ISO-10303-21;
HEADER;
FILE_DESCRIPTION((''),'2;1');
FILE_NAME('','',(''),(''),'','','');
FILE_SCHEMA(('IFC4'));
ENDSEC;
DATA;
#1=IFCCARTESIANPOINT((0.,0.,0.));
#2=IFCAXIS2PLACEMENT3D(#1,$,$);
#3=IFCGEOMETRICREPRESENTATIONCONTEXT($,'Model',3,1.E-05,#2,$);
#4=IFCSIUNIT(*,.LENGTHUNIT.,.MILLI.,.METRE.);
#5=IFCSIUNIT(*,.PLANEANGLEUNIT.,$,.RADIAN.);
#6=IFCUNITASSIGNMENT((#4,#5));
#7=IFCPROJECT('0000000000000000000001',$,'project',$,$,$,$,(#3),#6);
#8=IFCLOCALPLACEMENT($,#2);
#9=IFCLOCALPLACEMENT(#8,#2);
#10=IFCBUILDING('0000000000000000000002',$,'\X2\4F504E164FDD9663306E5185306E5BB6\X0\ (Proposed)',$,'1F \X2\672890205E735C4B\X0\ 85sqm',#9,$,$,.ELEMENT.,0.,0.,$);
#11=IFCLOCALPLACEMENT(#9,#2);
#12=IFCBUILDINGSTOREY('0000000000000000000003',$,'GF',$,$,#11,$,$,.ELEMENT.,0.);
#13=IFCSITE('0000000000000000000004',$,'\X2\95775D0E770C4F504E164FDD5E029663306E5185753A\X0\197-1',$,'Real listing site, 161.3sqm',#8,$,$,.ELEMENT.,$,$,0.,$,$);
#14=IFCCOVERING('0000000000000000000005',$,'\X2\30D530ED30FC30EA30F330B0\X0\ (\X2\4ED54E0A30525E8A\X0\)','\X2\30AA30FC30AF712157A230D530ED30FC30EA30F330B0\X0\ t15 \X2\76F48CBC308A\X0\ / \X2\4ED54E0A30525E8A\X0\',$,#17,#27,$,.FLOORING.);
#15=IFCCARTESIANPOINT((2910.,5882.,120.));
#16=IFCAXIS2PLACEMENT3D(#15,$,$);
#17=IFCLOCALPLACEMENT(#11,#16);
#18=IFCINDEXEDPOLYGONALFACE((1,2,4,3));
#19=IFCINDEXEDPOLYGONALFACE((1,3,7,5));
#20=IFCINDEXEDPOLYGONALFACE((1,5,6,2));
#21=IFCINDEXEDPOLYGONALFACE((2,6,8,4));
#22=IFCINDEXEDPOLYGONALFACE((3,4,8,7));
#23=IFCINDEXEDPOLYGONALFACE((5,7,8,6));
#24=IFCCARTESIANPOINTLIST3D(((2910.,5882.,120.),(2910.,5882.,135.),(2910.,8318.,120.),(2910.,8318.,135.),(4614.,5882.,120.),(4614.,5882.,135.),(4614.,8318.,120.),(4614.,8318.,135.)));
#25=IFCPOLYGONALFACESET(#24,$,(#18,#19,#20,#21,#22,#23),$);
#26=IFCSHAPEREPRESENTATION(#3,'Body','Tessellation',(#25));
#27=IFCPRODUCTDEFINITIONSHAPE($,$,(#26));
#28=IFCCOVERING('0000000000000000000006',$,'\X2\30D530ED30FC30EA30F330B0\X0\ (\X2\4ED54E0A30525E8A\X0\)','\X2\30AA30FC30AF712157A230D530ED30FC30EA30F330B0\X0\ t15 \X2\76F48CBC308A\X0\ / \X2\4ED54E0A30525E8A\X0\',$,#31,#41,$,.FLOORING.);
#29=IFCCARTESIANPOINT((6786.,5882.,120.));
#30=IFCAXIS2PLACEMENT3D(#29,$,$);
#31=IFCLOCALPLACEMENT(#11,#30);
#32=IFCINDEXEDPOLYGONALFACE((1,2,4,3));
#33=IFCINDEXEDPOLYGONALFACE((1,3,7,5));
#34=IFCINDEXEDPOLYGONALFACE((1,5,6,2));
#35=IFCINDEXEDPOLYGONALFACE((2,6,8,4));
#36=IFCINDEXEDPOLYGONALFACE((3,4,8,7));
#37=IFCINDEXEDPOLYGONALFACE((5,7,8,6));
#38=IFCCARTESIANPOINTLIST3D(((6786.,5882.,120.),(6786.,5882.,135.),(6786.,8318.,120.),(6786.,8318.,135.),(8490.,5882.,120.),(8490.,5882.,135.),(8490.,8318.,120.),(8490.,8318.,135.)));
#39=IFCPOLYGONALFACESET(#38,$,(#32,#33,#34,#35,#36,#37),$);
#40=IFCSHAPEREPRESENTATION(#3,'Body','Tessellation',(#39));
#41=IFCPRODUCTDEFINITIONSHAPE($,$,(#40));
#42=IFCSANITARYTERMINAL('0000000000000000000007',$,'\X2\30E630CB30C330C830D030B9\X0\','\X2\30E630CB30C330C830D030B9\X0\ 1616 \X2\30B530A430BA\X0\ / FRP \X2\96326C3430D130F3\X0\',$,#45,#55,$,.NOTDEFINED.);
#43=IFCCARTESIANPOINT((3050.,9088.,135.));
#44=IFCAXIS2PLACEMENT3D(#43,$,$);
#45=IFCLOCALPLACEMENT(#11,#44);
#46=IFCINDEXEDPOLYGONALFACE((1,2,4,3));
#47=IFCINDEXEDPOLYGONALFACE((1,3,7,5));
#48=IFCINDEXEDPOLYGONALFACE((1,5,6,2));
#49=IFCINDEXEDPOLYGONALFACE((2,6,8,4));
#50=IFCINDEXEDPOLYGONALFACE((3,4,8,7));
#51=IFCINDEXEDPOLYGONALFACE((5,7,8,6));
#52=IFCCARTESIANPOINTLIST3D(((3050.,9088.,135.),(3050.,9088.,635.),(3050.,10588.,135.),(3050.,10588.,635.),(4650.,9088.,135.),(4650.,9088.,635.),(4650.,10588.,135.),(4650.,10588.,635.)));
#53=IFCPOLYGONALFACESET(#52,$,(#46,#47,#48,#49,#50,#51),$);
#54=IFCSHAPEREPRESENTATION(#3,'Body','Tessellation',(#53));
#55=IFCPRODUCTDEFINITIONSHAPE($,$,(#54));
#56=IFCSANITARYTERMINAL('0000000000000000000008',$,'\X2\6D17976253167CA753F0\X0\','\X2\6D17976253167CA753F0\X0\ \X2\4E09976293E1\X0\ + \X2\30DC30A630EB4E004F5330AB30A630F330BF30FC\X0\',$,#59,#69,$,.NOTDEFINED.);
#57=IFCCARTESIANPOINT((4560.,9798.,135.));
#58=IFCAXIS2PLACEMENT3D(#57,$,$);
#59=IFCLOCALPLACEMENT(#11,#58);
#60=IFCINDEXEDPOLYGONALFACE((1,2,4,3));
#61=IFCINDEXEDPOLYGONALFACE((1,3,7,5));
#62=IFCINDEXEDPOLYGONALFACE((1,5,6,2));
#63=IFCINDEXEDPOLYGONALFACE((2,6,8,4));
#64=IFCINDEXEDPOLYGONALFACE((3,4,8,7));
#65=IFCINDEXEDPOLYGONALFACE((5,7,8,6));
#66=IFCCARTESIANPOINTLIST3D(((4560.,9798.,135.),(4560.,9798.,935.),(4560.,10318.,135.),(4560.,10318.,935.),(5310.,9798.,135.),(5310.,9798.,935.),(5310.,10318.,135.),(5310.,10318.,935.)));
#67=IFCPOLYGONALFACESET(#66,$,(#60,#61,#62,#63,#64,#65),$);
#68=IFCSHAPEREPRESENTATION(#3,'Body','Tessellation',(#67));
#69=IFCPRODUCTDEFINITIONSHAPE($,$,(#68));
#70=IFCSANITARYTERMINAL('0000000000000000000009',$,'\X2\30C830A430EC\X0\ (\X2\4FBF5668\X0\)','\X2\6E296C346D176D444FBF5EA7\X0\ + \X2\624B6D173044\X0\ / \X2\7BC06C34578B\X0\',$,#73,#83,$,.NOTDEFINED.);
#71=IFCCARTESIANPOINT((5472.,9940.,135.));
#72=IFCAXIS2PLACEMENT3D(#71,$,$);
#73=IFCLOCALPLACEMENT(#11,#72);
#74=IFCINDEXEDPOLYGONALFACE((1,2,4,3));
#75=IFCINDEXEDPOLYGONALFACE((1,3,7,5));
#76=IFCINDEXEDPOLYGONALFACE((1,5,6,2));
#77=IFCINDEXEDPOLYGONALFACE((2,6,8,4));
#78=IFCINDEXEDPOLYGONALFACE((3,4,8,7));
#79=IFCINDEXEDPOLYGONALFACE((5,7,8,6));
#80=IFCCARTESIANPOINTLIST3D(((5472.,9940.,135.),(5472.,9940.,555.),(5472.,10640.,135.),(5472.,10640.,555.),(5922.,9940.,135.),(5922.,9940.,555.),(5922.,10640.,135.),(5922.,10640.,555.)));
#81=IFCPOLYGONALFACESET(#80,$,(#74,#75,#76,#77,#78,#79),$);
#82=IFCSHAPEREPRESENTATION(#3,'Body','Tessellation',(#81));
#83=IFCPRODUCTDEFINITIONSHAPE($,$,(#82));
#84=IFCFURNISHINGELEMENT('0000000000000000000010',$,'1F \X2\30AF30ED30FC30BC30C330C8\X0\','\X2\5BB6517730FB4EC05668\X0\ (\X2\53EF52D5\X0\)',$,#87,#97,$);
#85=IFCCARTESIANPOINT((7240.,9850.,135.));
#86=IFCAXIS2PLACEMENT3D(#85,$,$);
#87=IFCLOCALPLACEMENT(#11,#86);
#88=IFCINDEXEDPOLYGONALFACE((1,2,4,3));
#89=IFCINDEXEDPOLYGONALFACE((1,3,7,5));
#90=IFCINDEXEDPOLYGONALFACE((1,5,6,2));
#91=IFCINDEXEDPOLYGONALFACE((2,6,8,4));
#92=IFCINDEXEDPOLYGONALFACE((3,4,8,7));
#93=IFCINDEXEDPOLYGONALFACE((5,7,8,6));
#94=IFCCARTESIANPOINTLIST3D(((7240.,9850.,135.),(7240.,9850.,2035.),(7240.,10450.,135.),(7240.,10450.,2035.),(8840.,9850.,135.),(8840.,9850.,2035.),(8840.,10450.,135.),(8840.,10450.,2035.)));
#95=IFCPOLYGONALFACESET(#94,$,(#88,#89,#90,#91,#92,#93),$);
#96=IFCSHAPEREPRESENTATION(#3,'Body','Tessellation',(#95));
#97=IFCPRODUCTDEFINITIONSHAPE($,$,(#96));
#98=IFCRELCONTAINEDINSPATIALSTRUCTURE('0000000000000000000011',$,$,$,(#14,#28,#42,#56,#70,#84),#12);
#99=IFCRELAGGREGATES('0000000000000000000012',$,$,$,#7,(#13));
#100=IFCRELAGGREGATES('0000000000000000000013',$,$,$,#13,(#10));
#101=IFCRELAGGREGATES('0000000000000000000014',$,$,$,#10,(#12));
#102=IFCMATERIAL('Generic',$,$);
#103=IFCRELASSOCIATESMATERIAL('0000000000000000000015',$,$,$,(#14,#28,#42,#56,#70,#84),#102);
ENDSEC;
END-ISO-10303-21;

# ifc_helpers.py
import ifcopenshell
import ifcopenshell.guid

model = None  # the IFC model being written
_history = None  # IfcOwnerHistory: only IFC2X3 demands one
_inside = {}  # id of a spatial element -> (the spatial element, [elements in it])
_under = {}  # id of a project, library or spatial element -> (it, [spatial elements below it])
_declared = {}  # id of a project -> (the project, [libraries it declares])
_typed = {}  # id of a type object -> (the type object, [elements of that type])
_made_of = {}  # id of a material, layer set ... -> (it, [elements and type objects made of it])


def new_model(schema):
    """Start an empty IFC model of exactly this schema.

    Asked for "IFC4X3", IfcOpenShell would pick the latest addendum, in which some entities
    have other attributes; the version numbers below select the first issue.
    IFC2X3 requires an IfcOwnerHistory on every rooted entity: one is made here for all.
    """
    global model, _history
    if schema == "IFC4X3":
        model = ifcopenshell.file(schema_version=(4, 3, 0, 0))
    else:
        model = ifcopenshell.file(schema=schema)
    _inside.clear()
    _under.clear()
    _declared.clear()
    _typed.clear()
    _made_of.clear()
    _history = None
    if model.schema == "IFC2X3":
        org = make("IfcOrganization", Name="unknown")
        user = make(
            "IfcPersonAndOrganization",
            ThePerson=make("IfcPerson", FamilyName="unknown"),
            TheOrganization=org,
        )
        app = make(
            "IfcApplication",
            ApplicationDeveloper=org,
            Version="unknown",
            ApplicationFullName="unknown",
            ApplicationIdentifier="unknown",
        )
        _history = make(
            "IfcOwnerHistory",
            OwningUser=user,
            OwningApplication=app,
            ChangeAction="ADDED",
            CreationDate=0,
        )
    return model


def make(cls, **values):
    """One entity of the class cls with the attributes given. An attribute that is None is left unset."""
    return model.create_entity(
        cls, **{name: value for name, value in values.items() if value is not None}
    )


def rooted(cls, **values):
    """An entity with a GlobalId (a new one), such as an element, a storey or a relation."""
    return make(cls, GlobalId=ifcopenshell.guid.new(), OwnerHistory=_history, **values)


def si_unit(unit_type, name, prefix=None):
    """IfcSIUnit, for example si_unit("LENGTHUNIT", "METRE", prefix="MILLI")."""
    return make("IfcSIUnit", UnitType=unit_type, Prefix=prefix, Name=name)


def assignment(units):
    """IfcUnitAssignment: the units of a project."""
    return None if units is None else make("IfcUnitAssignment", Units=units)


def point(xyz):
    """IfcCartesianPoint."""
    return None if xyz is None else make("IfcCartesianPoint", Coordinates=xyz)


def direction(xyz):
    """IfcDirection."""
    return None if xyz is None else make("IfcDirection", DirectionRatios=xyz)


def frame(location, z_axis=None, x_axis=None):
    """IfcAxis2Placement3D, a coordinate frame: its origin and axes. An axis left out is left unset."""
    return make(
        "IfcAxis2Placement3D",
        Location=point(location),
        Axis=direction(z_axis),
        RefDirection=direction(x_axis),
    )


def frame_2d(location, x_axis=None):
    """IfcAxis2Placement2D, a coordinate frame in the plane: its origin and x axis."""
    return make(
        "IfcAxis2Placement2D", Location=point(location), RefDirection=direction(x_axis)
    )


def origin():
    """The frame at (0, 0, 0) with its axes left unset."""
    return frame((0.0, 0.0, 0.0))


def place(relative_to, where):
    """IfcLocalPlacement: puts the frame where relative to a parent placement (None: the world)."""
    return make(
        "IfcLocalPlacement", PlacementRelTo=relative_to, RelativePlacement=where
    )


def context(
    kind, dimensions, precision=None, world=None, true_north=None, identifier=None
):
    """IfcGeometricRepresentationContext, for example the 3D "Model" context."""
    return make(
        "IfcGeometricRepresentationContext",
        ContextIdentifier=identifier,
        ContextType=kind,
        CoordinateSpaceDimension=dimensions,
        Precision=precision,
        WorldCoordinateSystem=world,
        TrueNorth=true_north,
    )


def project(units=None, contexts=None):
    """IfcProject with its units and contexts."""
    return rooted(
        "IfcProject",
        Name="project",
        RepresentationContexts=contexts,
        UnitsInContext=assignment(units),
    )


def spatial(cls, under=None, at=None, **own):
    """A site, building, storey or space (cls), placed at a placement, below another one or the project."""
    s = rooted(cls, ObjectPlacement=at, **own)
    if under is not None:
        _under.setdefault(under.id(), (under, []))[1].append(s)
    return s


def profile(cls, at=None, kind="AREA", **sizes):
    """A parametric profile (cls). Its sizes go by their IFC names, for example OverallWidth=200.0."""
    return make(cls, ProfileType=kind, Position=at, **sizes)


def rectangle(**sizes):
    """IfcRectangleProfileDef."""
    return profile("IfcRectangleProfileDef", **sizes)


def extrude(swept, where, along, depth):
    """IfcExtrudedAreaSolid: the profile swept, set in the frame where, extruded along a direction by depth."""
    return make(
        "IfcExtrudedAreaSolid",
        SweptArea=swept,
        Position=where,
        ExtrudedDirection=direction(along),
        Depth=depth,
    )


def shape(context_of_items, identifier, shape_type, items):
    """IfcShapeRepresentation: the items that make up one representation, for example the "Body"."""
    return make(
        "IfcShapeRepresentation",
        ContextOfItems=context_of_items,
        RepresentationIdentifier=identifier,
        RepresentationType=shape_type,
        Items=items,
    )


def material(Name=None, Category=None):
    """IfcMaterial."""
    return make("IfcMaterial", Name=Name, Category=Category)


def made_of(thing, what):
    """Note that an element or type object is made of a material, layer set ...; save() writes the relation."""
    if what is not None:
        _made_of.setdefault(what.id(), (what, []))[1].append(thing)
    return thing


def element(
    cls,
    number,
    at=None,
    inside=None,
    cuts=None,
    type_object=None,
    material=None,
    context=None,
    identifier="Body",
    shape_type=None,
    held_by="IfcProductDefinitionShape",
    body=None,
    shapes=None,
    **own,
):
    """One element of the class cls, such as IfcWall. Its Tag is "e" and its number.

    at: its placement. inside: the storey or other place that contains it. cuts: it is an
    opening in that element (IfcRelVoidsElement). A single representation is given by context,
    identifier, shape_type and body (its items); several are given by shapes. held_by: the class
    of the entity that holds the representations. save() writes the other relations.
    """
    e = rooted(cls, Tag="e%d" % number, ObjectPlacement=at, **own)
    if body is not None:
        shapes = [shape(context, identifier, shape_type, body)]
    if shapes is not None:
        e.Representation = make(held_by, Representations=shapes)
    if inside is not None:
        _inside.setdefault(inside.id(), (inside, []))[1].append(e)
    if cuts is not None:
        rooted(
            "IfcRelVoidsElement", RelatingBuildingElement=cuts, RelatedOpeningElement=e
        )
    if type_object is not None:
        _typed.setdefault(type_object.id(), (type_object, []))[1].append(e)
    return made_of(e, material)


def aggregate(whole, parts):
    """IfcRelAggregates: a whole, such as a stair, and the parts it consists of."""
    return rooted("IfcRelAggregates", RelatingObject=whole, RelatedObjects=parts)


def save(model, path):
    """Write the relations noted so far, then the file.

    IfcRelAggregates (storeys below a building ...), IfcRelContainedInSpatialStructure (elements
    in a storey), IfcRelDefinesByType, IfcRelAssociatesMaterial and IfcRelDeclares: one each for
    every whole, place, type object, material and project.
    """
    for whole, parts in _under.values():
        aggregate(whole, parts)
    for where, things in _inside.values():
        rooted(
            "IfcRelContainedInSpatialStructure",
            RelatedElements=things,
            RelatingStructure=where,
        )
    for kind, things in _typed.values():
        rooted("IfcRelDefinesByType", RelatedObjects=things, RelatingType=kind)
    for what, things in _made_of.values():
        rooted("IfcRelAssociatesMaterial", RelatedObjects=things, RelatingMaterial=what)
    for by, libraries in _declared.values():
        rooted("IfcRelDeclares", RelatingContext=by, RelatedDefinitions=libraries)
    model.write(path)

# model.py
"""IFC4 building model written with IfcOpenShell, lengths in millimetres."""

from ifc_helpers import new_model, si_unit, frame, frame_2d, origin, place, context, project, spatial, rectangle, extrude, material, element, save


model = new_model("IFC4")

# Units and contexts
model_context = context("Model", 3, precision=1e-05, world=origin())
ifc_project = project(units=[si_unit("LENGTHUNIT", "METRE", prefix="MILLI"), si_unit("PLANEANGLEUNIT", "RADIAN")], contexts=[model_context])

# Site, building, storey
site_placement = place(None, origin())
site = spatial("IfcSite", under=ifc_project, at=site_placement, Name="長崎県佐世保市陣の内町197-1", ObjectType="Real listing site, 161.3sqm", CompositionType="ELEMENT", RefElevation=0.0)
building_placement = place(site_placement, origin())
building = spatial("IfcBuilding", under=site, at=building_placement, Name="佐世保陣の内の家 (Proposed)", ObjectType="1F 木造平屋 85sqm", CompositionType="ELEMENT", ElevationOfRefHeight=0.0, ElevationOfTerrain=0.0)
storey_placement = place(building_placement, origin())
storey = spatial("IfcBuildingStorey", under=building, at=storey_placement, Name="GF", CompositionType="ELEMENT", Elevation=0.0)

# Coverings
ifc_material_1 = material(Name="Generic")
covering_1_placement = place(storey_placement, frame((2910.0, 5882.0, 120.0)))
element("IfcCovering", 1, at=covering_1_placement, inside=storey, material=ifc_material_1, Name="フローリング (仕上げ床)", Description="オーク無垢フローリング t15 直貼り / 仕上げ床", PredefinedType="FLOORING", context=model_context, shape_type="SweptSolid", body=[
    extrude(rectangle(XDim=1704.0, YDim=2436.0, at=frame_2d((852.0, 1218.0))), frame((2910.0, 5882.0, 120.0)), (0.0, 0.0, 1.0), 15.0),
])
covering_2_placement = place(storey_placement, frame((6786.0, 5882.0, 120.0)))
element("IfcCovering", 2, at=covering_2_placement, inside=storey, material=ifc_material_1, Name="フローリング (仕上げ床)", Description="オーク無垢フローリング t15 直貼り / 仕上げ床", PredefinedType="FLOORING", context=model_context, shape_type="SweptSolid", body=[
    extrude(rectangle(XDim=1704.0, YDim=2436.0, at=frame_2d((852.0, 1218.0))), frame((6786.0, 5882.0, 120.0)), (0.0, 0.0, 1.0), 15.0),
])

# Sanitary terminals
sanitary_terminal_1_placement = place(storey_placement, frame((3050.0, 9088.0, 135.0)))
element("IfcSanitaryTerminal", 3, at=sanitary_terminal_1_placement, inside=storey, material=ifc_material_1, Name="ユニットバス", Description="ユニットバス 1616 サイズ / FRP 防水パン", PredefinedType="NOTDEFINED", context=model_context, shape_type="SweptSolid", body=[
    extrude(rectangle(XDim=1600.0, YDim=1500.0, at=frame_2d((800.0, 750.0))), frame((3050.0, 9088.0, 135.0)), (0.0, 0.0, 1.0), 500.0),
])
sanitary_terminal_2_placement = place(storey_placement, frame((4560.0, 9798.0, 135.0)))
element("IfcSanitaryTerminal", 4, at=sanitary_terminal_2_placement, inside=storey, material=ifc_material_1, Name="洗面化粧台", Description="洗面化粧台 三面鏡 + ボウル一体カウンター", PredefinedType="NOTDEFINED", context=model_context, shape_type="SweptSolid", body=[
    extrude(rectangle(XDim=750.0, YDim=520.0, at=frame_2d((375.0, 260.0))), frame((4560.0, 9798.0, 135.0)), (0.0, 0.0, 1.0), 800.0),
])
sanitary_terminal_3_placement = place(storey_placement, frame((5472.0, 9940.0, 135.0)))
element("IfcSanitaryTerminal", 5, at=sanitary_terminal_3_placement, inside=storey, material=ifc_material_1, Name="トイレ (便器)", Description="温水洗浄便座 + 手洗い / 節水型", PredefinedType="NOTDEFINED", context=model_context, shape_type="SweptSolid", body=[
    extrude(rectangle(XDim=450.0, YDim=700.0, at=frame_2d((225.0, 350.0))), frame((5472.0, 9940.0, 135.0)), (0.0, 0.0, 1.0), 420.0),
])

# Furnishing element
furnishing_placement = place(storey_placement, frame((7240.0, 9850.0, 135.0)))
element("IfcFurnishingElement", 6, at=furnishing_placement, inside=storey, material=ifc_material_1, Name="1F クローゼット", Description="家具・什器 (可動)", context=model_context, shape_type="SweptSolid", body=[
    extrude(rectangle(XDim=1600.0, YDim=600.0, at=frame_2d((800.0, 300.0))), frame((7240.0, 9850.0, 135.0)), (0.0, 0.0, 1.0), 1900.0),
])

save(model, "model.ifc")
